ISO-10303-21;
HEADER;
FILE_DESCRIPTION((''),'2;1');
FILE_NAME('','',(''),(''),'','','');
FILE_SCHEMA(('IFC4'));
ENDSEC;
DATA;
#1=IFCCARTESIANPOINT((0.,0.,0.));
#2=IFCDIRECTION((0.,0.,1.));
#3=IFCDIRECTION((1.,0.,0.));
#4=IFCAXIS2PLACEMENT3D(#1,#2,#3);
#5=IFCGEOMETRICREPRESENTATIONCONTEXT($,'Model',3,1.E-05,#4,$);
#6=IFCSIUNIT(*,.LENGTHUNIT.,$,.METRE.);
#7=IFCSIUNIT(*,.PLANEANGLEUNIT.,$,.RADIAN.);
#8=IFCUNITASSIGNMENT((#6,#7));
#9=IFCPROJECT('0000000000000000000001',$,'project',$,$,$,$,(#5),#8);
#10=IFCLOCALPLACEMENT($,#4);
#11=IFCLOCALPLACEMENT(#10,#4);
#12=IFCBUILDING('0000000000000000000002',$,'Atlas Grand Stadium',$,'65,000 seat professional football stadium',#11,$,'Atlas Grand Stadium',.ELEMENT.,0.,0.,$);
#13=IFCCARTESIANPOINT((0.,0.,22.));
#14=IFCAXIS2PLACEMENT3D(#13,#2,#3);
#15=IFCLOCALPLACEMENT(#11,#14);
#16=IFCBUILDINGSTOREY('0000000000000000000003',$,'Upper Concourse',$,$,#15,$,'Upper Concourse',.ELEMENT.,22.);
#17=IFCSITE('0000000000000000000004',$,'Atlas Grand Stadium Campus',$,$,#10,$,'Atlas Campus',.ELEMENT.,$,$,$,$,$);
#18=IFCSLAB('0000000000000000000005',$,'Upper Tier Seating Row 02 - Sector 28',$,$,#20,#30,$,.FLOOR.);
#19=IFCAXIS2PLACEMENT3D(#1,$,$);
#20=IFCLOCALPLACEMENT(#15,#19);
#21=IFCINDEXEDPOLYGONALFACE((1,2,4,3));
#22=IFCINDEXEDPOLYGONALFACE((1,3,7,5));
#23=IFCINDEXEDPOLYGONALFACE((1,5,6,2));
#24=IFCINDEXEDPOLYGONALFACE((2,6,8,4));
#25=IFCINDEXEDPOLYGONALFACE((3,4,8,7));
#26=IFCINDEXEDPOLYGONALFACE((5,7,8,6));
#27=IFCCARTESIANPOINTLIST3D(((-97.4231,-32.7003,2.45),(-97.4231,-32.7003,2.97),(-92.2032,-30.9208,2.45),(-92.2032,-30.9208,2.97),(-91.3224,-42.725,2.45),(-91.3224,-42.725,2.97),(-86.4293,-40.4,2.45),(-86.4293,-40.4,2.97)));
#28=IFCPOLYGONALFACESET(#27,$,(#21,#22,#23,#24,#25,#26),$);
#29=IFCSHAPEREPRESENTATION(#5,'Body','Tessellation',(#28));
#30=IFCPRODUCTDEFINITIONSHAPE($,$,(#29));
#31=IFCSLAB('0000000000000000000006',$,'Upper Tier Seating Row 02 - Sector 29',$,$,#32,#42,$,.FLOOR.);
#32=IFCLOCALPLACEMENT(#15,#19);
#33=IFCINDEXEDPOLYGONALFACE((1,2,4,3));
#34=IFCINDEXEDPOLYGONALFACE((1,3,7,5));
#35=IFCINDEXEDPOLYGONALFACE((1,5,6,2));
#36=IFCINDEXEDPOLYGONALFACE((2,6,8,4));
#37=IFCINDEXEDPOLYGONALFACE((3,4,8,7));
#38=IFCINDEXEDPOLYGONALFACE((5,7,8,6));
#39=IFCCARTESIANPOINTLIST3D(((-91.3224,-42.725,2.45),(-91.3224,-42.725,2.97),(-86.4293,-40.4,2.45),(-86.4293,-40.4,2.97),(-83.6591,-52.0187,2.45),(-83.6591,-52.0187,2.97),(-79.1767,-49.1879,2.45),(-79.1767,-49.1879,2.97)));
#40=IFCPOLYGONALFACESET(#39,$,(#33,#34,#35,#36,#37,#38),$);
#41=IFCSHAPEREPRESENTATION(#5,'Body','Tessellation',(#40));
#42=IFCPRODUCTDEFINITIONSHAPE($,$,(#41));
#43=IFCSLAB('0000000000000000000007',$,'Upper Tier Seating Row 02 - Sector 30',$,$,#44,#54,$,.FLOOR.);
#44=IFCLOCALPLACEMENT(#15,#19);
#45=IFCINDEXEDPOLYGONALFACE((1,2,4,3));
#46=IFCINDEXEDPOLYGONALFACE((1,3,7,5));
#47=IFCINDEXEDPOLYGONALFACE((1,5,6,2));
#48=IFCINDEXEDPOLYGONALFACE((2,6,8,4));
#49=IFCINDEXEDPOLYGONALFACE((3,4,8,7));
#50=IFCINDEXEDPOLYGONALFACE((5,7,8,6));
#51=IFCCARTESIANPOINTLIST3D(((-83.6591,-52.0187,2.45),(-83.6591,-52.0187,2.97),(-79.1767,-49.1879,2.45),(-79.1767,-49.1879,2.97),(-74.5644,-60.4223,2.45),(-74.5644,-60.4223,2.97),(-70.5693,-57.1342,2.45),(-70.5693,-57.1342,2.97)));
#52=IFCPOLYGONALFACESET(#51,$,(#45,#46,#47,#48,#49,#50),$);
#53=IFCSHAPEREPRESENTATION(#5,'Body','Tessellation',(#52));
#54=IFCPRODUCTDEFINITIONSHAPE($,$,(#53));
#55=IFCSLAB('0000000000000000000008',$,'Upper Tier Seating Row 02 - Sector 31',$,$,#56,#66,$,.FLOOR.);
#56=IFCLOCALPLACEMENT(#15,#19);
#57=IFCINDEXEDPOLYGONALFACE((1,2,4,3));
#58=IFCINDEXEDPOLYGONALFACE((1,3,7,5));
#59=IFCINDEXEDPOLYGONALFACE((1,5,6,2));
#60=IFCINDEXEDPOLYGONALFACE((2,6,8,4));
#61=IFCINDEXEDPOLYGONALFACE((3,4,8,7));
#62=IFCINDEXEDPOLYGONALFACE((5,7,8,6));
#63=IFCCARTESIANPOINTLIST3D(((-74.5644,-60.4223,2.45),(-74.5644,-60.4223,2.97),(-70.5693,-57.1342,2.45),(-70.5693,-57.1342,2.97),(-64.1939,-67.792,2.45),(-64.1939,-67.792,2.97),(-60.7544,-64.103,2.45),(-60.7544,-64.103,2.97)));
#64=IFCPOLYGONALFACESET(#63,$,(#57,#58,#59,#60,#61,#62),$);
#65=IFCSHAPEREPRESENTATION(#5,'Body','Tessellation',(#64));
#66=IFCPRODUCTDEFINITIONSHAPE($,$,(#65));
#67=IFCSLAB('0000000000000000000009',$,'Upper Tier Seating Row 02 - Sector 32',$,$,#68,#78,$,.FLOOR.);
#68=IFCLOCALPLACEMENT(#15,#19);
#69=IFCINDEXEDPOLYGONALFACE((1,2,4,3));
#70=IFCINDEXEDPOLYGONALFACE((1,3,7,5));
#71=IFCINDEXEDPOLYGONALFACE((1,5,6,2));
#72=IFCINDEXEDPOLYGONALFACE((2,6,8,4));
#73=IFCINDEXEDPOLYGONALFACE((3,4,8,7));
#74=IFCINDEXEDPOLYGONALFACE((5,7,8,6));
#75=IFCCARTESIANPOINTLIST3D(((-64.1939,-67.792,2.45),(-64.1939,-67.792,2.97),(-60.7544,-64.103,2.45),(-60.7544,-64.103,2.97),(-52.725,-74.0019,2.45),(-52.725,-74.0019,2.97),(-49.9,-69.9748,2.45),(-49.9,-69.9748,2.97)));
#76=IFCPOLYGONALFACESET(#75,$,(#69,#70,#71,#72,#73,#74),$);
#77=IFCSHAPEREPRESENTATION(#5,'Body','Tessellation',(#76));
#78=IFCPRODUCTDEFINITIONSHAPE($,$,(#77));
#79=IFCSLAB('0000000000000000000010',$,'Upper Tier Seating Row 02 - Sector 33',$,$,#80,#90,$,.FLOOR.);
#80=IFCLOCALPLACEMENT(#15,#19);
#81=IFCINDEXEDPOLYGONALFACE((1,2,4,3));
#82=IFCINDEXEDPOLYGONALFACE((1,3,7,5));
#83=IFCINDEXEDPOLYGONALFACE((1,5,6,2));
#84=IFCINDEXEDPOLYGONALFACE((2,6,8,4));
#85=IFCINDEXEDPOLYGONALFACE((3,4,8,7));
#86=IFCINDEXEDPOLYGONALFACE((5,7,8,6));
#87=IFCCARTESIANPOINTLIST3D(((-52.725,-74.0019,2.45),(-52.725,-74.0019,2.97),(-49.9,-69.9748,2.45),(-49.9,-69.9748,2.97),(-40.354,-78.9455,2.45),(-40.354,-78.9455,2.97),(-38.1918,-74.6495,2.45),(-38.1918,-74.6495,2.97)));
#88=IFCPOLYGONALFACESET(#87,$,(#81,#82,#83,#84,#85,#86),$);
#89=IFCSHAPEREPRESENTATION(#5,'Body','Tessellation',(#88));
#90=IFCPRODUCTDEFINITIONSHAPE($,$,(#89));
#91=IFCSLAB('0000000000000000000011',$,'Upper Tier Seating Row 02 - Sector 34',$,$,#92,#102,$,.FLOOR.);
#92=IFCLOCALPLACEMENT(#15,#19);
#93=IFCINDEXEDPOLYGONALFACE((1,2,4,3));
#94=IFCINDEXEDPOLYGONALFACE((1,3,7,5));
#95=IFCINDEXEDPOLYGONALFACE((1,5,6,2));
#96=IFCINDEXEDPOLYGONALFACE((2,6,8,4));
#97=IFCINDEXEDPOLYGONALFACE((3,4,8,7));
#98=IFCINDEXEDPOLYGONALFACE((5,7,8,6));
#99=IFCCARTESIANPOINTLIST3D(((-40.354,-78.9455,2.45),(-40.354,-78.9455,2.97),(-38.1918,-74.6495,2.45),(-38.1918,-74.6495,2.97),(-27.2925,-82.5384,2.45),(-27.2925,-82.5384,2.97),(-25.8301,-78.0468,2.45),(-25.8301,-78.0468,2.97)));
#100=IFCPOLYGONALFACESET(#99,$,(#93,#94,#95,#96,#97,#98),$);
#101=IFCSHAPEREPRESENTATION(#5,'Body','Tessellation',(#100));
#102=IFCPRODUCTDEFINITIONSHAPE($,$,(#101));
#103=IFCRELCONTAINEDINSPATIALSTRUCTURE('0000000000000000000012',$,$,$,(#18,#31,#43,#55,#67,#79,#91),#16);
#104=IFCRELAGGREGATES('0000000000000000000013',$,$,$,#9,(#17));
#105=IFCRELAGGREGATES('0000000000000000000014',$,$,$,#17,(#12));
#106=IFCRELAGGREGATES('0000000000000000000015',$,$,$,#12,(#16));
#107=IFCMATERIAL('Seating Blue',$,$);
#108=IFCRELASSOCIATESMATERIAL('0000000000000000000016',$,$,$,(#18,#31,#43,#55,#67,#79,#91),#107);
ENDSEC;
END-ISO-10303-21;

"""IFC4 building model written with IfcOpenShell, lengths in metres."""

from ifc_helpers import new_model, si_unit, frame, origin_with_axes, place, context, project, spatial, polyline, outline, extrude, material, element, save


model = new_model("IFC4")

# Units and contexts
model_context = context("Model", 3, precision=1e-05, world=origin_with_axes())
ifc_project = project(units=[si_unit("LENGTHUNIT", "METRE"), si_unit("PLANEANGLEUNIT", "RADIAN")], contexts=[model_context])

# Site, building, storey
site_placement = place(None, origin_with_axes())
site = spatial("IfcSite", under=ifc_project, at=site_placement, Name="Atlas Grand Stadium Campus", LongName="Atlas Campus", CompositionType="ELEMENT")
building_placement = place(site_placement, origin_with_axes())
building = spatial("IfcBuilding", under=site, at=building_placement, Name="Atlas Grand Stadium", ObjectType="65,000 seat professional football stadium", LongName="Atlas Grand Stadium", CompositionType="ELEMENT", ElevationOfRefHeight=0.0, ElevationOfTerrain=0.0)
storey_placement = place(building_placement, frame((0.0, 0.0, 22.0), z_axis=(0.0, 0.0, 1.0), x_axis=(1.0, 0.0, 0.0)))
storey = spatial("IfcBuildingStorey", under=building, at=storey_placement, Name="Upper Concourse", LongName="Upper Concourse", CompositionType="ELEMENT", Elevation=22.0)

# Slabs
ifc_material_1 = material(Name="Seating Blue")
slab_1_placement = place(storey_placement, frame((0.0, 0.0, 2.45), z_axis=(0.0, 0.0, 1.0), x_axis=(1.0, 0.0, 0.0)))
element("IfcSlab", 1, at=slab_1_placement, inside=storey, material=ifc_material_1, Name="Upper Tier Seating Row 02 - Sector 28", PredefinedType="FLOOR", context=model_context, shape_type="SweptSolid", body=[
    extrude(outline(polyline([(-97.4231, -32.7003), (-91.3224, -42.725), (-86.4293, -40.4), (-92.2032, -30.9208), (-97.4231, -32.7003)])), origin_with_axes(), (0.0, 0.0, 1.0), 0.52),
])
slab_2_placement = place(storey_placement, frame((0.0, 0.0, 2.45), z_axis=(0.0, 0.0, 1.0), x_axis=(1.0, 0.0, 0.0)))
element("IfcSlab", 2, at=slab_2_placement, inside=storey, material=ifc_material_1, Name="Upper Tier Seating Row 02 - Sector 29", PredefinedType="FLOOR", context=model_context, shape_type="SweptSolid", body=[
    extrude(outline(polyline([(-91.3224, -42.725), (-83.6591, -52.0187), (-79.1767, -49.1879), (-86.4293, -40.4), (-91.3224, -42.725)])), origin_with_axes(), (0.0, 0.0, 1.0), 0.52),
])
slab_3_placement = place(storey_placement, frame((0.0, 0.0, 2.45), z_axis=(0.0, 0.0, 1.0), x_axis=(1.0, 0.0, 0.0)))
element("IfcSlab", 3, at=slab_3_placement, inside=storey, material=ifc_material_1, Name="Upper Tier Seating Row 02 - Sector 30", PredefinedType="FLOOR", context=model_context, shape_type="SweptSolid", body=[
    extrude(outline(polyline([(-83.6591, -52.0187), (-74.5644, -60.4223), (-70.5693, -57.1342), (-79.1767, -49.1879), (-83.6591, -52.0187)])), origin_with_axes(), (0.0, 0.0, 1.0), 0.52),
])
slab_4_placement = place(storey_placement, frame((0.0, 0.0, 2.45), z_axis=(0.0, 0.0, 1.0), x_axis=(1.0, 0.0, 0.0)))
element("IfcSlab", 4, at=slab_4_placement, inside=storey, material=ifc_material_1, Name="Upper Tier Seating Row 02 - Sector 31", PredefinedType="FLOOR", context=model_context, shape_type="SweptSolid", body=[
    extrude(outline(polyline([(-74.5644, -60.4223), (-64.1939, -67.792), (-60.7544, -64.103), (-70.5693, -57.1342), (-74.5644, -60.4223)])), origin_with_axes(), (0.0, 0.0, 1.0), 0.52),
])
slab_5_placement = place(storey_placement, frame((0.0, 0.0, 2.45), z_axis=(0.0, 0.0, 1.0), x_axis=(1.0, 0.0, 0.0)))
element("IfcSlab", 5, at=slab_5_placement, inside=storey, material=ifc_material_1, Name="Upper Tier Seating Row 02 - Sector 32", PredefinedType="FLOOR", context=model_context, shape_type="SweptSolid", body=[
    extrude(outline(polyline([(-64.1939, -67.792), (-52.725, -74.0019), (-49.9, -69.9749), (-60.7544, -64.103), (-64.1939, -67.792)])), origin_with_axes(), (0.0, 0.0, 1.0), 0.52),
])
slab_6_placement = place(storey_placement, frame((0.0, 0.0, 2.45), z_axis=(0.0, 0.0, 1.0), x_axis=(1.0, 0.0, 0.0)))
element("IfcSlab", 6, at=slab_6_placement, inside=storey, material=ifc_material_1, Name="Upper Tier Seating Row 02 - Sector 33", PredefinedType="FLOOR", context=model_context, shape_type="SweptSolid", body=[
    extrude(outline(polyline([(-52.725, -74.0019), (-40.354, -78.9455), (-38.1918, -74.6495), (-49.9, -69.9749), (-52.725, -74.0019)])), origin_with_axes(), (0.0, 0.0, 1.0), 0.52),
])
slab_7_placement = place(storey_placement, frame((0.0, 0.0, 2.45), z_axis=(0.0, 0.0, 1.0), x_axis=(1.0, 0.0, 0.0)))
element("IfcSlab", 7, at=slab_7_placement, inside=storey, material=ifc_material_1, Name="Upper Tier Seating Row 02 - Sector 34", PredefinedType="FLOOR", context=model_context, shape_type="SweptSolid", body=[
    extrude(outline(polyline([(-40.354, -78.9455), (-27.2925, -82.5384), (-25.8301, -78.0468), (-38.1918, -74.6495), (-40.354, -78.9455)])), origin_with_axes(), (0.0, 0.0, 1.0), 0.52),
])

save(model, "model.ifc")
